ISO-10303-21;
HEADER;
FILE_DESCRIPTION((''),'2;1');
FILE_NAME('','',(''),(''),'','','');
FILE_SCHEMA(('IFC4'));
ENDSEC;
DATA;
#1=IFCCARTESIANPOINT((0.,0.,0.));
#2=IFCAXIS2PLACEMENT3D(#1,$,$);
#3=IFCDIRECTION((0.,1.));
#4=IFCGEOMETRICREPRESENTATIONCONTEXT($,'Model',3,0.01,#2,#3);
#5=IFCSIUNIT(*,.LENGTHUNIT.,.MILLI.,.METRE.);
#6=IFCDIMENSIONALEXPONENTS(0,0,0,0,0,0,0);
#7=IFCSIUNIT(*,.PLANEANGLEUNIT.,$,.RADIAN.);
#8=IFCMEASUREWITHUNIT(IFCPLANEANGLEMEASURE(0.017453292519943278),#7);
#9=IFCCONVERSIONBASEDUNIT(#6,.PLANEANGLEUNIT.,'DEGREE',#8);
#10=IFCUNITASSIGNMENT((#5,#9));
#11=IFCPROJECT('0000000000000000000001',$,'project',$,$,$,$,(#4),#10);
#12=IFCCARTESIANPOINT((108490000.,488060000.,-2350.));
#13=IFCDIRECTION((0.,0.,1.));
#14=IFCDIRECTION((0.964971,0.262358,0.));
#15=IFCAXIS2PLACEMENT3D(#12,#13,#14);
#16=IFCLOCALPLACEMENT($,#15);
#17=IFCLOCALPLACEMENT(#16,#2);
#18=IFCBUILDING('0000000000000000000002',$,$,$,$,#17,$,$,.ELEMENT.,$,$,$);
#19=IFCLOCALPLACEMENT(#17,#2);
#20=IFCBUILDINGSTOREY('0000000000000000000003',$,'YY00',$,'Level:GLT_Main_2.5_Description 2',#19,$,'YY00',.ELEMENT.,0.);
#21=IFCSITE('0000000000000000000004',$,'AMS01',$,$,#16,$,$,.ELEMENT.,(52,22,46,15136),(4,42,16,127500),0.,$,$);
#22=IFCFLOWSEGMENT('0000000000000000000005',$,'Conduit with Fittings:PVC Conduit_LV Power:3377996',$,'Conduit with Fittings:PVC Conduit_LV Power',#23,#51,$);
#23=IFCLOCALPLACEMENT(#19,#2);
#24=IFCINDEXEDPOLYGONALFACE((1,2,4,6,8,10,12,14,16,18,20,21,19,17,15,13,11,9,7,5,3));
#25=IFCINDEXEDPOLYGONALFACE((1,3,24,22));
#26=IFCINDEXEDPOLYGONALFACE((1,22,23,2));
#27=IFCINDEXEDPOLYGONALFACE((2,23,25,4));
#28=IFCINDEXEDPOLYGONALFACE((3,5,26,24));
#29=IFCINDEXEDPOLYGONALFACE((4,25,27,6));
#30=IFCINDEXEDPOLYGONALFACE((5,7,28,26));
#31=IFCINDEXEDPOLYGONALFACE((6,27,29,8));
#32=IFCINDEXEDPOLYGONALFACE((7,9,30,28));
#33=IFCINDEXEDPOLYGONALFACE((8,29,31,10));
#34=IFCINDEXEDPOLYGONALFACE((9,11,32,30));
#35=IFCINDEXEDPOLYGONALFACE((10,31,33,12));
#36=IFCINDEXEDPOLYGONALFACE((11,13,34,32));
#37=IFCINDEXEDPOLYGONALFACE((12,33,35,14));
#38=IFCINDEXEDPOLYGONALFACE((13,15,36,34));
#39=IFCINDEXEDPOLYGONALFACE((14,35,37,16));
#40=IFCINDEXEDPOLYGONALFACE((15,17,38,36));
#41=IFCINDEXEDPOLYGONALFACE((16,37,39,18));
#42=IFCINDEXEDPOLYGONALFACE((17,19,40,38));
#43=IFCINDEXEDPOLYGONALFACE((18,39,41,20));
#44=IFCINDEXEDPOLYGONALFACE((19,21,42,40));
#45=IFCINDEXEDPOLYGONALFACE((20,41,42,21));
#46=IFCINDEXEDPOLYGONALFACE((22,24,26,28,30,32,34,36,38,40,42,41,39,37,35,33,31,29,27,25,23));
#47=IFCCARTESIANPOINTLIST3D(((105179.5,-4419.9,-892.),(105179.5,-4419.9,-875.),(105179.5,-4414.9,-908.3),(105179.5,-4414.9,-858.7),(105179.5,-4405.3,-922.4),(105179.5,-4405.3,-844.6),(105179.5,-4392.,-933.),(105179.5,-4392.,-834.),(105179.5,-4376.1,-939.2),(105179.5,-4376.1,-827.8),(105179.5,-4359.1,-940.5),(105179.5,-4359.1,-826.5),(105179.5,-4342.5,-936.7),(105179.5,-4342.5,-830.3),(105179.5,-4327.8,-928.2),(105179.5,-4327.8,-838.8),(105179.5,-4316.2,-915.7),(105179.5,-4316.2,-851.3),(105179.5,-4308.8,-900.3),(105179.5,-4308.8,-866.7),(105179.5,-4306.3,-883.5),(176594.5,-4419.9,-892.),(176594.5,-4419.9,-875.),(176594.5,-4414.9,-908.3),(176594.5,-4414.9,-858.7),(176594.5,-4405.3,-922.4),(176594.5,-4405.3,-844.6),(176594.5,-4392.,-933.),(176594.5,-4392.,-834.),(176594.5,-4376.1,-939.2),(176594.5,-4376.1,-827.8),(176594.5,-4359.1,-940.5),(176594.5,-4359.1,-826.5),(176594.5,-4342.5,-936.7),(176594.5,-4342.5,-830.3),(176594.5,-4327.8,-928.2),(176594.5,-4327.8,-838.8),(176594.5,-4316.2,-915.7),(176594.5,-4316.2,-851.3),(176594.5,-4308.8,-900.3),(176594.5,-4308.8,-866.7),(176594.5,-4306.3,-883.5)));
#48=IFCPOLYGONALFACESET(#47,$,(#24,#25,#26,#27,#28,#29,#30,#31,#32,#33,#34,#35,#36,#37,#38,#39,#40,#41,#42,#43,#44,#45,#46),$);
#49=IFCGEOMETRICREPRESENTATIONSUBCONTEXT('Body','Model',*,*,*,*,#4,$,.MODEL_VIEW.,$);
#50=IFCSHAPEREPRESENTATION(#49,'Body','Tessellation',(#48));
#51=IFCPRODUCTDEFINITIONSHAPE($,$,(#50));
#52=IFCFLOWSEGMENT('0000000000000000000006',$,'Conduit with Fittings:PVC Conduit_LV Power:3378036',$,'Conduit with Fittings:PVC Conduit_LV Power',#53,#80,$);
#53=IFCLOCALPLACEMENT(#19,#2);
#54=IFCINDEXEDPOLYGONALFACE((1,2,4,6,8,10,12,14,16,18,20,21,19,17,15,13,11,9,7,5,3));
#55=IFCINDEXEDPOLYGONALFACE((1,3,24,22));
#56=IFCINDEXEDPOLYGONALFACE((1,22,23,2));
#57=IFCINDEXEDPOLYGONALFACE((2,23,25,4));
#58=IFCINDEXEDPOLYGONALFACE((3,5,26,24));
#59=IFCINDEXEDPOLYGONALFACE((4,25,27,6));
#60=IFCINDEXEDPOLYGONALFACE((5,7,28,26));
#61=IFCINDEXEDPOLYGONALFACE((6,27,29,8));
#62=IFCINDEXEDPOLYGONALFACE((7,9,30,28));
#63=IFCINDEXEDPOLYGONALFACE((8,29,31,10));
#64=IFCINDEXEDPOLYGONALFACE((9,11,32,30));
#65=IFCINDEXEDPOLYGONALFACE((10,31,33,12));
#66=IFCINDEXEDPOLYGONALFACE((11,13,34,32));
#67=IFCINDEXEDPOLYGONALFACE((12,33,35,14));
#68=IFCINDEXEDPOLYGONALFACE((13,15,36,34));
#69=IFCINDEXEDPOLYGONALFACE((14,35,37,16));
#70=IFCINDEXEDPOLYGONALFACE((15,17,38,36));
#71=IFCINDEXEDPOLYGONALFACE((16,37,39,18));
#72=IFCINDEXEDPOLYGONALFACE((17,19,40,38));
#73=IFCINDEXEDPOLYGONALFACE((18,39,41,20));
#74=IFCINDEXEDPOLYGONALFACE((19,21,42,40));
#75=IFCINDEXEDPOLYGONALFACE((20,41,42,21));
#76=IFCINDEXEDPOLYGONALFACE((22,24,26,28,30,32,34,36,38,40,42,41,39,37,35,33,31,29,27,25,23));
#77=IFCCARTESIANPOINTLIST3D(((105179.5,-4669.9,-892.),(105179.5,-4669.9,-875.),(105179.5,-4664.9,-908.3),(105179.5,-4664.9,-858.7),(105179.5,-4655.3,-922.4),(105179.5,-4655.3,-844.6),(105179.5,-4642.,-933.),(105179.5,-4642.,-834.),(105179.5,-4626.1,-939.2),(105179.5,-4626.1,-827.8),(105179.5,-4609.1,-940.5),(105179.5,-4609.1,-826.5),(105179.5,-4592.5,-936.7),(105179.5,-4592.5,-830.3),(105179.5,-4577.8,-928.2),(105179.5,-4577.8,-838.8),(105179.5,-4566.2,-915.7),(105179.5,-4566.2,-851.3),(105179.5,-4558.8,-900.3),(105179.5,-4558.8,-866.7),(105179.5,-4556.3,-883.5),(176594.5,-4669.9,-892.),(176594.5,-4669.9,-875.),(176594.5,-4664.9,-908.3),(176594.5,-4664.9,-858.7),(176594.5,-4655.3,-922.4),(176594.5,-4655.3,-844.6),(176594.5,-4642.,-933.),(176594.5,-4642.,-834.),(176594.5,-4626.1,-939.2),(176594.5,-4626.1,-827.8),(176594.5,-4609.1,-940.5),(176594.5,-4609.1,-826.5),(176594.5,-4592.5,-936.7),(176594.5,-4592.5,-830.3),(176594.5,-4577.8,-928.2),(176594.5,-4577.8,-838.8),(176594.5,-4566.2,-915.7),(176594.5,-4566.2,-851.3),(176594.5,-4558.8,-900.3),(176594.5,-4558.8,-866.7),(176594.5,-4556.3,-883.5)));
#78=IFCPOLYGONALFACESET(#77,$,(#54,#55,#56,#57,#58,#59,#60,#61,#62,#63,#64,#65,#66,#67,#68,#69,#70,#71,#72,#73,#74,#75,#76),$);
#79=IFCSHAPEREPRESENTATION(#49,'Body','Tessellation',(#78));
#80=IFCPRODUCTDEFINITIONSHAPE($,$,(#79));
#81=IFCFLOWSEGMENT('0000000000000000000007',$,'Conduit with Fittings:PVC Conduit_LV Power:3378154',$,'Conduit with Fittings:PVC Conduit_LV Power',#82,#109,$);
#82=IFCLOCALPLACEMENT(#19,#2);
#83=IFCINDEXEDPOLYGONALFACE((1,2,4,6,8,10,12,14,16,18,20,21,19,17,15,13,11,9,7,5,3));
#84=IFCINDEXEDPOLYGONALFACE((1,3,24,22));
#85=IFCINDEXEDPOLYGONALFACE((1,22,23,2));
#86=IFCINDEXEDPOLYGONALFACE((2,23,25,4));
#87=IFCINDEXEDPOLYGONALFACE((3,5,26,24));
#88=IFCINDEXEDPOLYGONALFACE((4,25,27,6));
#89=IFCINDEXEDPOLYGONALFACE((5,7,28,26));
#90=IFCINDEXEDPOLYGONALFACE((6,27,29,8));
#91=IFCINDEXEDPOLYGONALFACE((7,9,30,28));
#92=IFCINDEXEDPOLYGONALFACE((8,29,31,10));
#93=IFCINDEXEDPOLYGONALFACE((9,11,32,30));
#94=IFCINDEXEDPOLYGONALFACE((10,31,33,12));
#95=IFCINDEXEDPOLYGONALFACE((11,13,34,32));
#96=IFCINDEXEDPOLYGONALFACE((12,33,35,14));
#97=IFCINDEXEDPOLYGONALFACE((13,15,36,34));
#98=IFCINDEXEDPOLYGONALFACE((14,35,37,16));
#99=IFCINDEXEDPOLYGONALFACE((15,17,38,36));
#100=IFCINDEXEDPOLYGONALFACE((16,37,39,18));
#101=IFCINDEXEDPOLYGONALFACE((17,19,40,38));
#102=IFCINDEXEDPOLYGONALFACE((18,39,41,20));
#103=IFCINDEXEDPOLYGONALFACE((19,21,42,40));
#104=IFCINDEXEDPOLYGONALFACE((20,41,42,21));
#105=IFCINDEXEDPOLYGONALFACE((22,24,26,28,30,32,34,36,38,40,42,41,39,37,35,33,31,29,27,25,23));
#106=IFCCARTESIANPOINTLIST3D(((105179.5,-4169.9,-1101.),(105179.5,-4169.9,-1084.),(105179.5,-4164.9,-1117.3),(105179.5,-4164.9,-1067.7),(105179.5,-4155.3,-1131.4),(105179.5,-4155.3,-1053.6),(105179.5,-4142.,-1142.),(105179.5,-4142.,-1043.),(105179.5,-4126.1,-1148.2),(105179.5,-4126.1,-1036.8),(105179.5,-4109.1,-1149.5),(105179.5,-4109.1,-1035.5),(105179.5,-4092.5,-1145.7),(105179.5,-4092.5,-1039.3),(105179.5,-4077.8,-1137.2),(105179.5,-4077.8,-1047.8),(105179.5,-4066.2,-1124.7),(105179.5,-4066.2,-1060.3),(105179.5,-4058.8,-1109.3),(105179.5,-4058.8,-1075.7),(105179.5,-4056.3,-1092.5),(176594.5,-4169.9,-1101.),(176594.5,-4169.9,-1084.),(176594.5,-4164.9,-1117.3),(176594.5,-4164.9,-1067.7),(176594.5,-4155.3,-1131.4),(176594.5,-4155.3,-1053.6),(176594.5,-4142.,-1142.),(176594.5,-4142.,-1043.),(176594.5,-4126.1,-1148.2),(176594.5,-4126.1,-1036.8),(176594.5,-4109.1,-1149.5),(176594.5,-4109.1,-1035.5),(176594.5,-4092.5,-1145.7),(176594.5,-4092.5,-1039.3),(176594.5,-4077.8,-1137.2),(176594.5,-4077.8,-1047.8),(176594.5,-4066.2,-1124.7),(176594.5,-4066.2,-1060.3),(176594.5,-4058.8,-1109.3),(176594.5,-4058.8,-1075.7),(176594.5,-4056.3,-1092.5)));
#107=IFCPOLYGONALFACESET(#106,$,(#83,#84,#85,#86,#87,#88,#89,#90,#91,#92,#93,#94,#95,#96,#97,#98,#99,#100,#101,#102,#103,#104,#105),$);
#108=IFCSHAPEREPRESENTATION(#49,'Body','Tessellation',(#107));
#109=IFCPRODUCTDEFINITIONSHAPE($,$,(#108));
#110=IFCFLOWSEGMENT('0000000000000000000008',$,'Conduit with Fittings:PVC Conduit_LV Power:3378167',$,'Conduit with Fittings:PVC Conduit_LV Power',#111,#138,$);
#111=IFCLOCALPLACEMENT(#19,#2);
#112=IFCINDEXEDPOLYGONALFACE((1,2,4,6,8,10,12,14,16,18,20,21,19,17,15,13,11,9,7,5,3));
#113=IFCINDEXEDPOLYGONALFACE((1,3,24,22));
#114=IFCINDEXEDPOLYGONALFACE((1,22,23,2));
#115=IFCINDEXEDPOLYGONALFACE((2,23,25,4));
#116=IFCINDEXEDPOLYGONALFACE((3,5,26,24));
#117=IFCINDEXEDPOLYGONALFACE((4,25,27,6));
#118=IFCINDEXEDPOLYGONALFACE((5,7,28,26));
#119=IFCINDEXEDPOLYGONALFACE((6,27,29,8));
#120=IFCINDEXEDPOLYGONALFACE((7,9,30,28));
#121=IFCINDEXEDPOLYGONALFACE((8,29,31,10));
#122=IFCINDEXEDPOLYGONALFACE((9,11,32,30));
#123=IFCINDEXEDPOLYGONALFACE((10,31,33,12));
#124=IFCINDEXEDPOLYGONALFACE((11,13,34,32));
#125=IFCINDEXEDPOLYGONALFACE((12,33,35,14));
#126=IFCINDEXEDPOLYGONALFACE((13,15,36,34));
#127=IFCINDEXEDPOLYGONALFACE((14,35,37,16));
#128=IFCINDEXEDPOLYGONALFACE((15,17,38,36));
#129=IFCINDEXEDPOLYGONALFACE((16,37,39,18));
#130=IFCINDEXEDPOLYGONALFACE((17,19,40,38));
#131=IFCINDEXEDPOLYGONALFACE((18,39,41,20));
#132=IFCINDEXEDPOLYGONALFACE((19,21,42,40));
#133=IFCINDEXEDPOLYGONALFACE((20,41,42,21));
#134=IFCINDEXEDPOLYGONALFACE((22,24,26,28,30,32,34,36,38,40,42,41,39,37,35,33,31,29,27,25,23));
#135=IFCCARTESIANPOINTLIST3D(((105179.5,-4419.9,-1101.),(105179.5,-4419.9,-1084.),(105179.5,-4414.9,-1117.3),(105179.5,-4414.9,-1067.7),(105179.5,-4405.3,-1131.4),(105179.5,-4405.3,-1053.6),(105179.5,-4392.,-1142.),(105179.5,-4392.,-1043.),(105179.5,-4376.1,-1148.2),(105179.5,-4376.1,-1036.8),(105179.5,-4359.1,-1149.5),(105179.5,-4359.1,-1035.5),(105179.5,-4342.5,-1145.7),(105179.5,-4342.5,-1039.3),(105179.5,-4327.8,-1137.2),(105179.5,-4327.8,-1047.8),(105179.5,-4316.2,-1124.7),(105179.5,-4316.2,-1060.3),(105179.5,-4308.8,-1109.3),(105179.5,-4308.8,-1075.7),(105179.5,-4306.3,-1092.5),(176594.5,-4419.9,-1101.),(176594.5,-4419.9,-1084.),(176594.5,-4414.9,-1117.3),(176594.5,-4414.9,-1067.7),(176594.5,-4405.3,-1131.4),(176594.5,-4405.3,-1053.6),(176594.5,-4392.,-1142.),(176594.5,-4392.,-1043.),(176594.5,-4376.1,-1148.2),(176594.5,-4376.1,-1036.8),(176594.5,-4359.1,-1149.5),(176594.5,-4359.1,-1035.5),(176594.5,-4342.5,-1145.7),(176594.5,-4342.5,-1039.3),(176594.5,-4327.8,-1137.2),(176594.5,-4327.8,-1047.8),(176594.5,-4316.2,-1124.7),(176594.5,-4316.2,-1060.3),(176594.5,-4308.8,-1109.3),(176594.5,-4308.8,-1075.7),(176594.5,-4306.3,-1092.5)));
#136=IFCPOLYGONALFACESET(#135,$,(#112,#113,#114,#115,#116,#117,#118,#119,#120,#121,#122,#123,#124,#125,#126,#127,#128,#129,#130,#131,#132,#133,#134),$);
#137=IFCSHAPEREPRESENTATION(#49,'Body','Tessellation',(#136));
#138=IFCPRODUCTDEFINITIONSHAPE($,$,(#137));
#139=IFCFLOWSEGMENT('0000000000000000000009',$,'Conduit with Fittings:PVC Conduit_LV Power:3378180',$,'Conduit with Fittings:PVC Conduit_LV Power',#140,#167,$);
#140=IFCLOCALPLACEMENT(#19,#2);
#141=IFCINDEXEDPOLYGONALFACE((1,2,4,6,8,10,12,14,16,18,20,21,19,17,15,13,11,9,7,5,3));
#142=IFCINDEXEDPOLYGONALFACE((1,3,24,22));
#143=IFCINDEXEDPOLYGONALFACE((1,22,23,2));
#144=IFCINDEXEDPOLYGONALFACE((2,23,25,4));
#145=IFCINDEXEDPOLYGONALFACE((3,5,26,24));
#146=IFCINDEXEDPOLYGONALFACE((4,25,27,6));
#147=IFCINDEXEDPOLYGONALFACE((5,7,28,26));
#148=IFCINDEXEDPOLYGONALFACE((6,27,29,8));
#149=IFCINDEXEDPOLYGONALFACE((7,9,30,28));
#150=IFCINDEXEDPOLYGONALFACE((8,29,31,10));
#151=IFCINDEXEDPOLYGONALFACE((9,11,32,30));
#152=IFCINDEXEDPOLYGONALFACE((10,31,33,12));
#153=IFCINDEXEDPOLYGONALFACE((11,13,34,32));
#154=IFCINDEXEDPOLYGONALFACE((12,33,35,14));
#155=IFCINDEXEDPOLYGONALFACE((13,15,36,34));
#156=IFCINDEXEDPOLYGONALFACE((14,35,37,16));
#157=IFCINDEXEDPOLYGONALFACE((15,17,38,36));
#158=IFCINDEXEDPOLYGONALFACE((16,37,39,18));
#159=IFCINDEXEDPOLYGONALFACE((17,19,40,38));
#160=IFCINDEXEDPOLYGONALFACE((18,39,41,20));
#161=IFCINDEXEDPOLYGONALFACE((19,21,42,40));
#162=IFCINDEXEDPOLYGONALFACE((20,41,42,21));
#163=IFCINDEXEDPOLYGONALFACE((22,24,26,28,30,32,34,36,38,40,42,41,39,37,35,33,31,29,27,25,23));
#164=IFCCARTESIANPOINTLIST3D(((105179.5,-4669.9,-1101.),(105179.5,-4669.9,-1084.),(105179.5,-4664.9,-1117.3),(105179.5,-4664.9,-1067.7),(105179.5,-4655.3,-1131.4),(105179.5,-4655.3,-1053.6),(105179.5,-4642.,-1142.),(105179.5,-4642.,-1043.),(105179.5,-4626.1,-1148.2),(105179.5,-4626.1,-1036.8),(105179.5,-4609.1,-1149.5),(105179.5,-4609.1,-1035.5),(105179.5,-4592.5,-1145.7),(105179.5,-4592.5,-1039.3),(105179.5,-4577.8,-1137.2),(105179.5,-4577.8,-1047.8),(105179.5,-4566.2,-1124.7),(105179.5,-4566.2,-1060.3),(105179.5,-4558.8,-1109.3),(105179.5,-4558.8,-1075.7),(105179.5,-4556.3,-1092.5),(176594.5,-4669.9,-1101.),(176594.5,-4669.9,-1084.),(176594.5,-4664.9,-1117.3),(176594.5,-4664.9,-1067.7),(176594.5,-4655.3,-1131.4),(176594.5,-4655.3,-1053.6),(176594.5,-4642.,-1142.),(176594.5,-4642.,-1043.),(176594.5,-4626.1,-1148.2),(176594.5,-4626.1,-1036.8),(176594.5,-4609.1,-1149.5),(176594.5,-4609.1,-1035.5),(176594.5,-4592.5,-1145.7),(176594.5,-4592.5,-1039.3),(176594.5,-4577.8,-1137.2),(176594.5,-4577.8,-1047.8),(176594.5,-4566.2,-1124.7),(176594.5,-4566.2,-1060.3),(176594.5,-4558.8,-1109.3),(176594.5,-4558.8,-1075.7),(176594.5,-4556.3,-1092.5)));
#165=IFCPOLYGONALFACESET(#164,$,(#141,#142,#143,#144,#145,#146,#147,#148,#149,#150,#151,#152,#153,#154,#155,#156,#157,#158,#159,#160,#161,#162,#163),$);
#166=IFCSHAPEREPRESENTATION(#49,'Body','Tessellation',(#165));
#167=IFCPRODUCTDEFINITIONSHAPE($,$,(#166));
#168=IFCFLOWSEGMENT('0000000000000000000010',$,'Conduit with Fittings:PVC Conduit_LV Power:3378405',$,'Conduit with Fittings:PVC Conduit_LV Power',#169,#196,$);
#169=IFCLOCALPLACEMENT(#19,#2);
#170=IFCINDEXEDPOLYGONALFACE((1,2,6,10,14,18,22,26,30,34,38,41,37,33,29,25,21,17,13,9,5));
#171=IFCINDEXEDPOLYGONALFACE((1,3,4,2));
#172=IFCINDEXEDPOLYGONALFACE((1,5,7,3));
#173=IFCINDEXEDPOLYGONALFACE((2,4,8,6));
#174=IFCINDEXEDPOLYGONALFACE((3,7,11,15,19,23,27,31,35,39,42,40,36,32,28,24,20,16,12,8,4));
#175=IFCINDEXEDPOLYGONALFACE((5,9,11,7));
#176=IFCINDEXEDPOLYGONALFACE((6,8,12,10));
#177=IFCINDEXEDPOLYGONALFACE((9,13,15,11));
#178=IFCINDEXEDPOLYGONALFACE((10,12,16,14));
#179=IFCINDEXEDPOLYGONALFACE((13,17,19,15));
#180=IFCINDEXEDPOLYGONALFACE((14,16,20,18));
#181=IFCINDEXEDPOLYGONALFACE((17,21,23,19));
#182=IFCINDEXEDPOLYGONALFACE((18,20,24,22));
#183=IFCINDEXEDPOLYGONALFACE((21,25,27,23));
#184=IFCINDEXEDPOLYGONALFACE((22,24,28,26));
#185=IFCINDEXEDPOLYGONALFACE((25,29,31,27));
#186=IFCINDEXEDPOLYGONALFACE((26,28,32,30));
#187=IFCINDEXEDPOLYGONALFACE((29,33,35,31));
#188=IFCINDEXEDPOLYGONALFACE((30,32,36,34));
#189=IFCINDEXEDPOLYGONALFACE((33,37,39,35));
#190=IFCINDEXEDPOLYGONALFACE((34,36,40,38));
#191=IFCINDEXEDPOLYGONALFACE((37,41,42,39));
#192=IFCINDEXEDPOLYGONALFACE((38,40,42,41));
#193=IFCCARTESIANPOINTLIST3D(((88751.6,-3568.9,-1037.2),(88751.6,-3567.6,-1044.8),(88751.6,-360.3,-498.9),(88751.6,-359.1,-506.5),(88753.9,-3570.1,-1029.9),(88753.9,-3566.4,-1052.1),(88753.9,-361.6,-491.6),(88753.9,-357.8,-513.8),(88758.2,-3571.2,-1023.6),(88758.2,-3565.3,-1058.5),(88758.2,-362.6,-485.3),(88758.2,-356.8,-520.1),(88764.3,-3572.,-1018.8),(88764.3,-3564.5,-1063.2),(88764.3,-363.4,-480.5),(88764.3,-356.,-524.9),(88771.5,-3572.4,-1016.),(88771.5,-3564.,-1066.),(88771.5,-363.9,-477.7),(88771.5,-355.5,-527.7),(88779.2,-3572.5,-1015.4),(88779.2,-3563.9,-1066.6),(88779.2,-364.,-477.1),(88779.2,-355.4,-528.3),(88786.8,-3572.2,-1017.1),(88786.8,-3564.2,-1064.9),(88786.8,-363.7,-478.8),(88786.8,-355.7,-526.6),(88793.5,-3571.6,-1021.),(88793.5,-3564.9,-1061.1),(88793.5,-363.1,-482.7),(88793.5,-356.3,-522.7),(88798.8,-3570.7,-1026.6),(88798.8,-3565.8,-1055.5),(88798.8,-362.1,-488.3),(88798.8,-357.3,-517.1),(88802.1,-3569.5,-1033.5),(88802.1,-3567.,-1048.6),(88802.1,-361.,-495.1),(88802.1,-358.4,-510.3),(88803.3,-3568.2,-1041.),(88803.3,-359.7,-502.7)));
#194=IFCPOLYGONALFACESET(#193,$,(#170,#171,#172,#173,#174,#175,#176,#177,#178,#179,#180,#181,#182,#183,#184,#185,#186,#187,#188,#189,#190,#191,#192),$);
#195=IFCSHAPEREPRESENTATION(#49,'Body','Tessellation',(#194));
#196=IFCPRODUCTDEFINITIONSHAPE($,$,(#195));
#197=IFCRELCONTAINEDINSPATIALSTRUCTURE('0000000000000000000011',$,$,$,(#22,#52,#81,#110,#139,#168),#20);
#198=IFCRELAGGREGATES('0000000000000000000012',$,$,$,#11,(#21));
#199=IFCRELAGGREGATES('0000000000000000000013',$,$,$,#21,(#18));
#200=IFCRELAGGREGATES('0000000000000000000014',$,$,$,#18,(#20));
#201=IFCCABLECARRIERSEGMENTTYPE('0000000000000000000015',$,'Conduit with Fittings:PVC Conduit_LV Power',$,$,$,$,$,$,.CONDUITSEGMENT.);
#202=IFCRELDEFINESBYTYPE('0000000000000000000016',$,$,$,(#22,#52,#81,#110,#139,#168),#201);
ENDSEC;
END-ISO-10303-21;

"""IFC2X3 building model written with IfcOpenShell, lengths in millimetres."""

from ifc_helpers import new_model, entity, si_unit, converted_unit, direction, frame, frame_2d, origin, place, context, subcontext, project, spatial, circle, extrude, type_object, element, save


model = new_model("IFC2X3")

# Units and contexts
model_context = context("Model", 3, precision=0.01, world=origin(), true_north=direction((0.0, 1.0)))
body_context = subcontext(model_context, "Body", "Model", "MODEL_VIEW")
ifc_project = project(units=[si_unit("LENGTHUNIT", "METRE", prefix="MILLI"), converted_unit("PLANEANGLEUNIT", "DEGREE", entity("IfcPlaneAngleMeasure", 0.017453292519943278), si_unit("PLANEANGLEUNIT", "RADIAN"), dimensions=[0, 0, 0, 0, 0, 0, 0])], contexts=[model_context])

# Site, building, storey
site_placement = place(None, frame((108490000.0, 488060000.0, -2350.0), z_axis=(0.0, 0.0, 1.0), x_axis=(0.964971, 0.262358, 0.0)))
site = spatial("IfcSite", under=ifc_project, at=site_placement, Name="AMS01", CompositionType="ELEMENT", RefLatitude=(52, 22, 46, 15136), RefLongitude=(4, 42, 16, 127500), RefElevation=0.0)
building_placement = place(site_placement, origin())
building = spatial("IfcBuilding", under=site, at=building_placement, CompositionType="ELEMENT")
storey_placement = place(building_placement, origin())
storey = spatial("IfcBuildingStorey", under=building, at=storey_placement, Name="YY00", ObjectType="Level:GLT_Main_2.5_Description 2", LongName="YY00", CompositionType="ELEMENT", Elevation=0.0)

# Flow segments
cable_carrier_segment_type = type_object("IfcCableCarrierSegmentType", Name="Conduit with Fittings:PVC Conduit_LV Power", PredefinedType="CONDUITSEGMENT")
flow_segment_1_placement = place(storey_placement, origin())
element("IfcFlowSegment", 1, at=flow_segment_1_placement, inside=storey, type_object=cable_carrier_segment_type, Name="Conduit with Fittings:PVC Conduit_LV Power:3377996", ObjectType="Conduit with Fittings:PVC Conduit_LV Power", context=body_context, shape_type="SweptSolid", body=[
    extrude(circle(Radius=57.2, at=frame_2d((0.0, 0.0), x_axis=(1.0, 0.0))), frame((105179.5, -4363.4, -883.5), z_axis=(1.0, 0.0, 0.0), x_axis=(0.0, 1.0, 0.0)), (0.0, 0.0, 1.0), 71415.0),
])
flow_segment_2_placement = place(storey_placement, origin())
element("IfcFlowSegment", 2, at=flow_segment_2_placement, inside=storey, type_object=cable_carrier_segment_type, Name="Conduit with Fittings:PVC Conduit_LV Power:3378036", ObjectType="Conduit with Fittings:PVC Conduit_LV Power", context=body_context, shape_type="SweptSolid", body=[
    extrude(circle(Radius=57.2, at=frame_2d((0.0, 0.0), x_axis=(1.0, 0.0))), frame((105179.5, -4613.4, -883.5), z_axis=(1.0, 0.0, 0.0), x_axis=(0.0, 1.0, 0.0)), (0.0, 0.0, 1.0), 71415.0),
])
flow_segment_3_placement = place(storey_placement, origin())
element("IfcFlowSegment", 3, at=flow_segment_3_placement, inside=storey, type_object=cable_carrier_segment_type, Name="Conduit with Fittings:PVC Conduit_LV Power:3378154", ObjectType="Conduit with Fittings:PVC Conduit_LV Power", context=body_context, shape_type="SweptSolid", body=[
    extrude(circle(Radius=57.2, at=frame_2d((0.0, 0.0), x_axis=(1.0, 0.0))), frame((105179.5, -4113.4, -1092.5), z_axis=(1.0, 0.0, 0.0), x_axis=(0.0, 1.0, 0.0)), (0.0, 0.0, 1.0), 71415.0),
])
flow_segment_4_placement = place(storey_placement, origin())
element("IfcFlowSegment", 4, at=flow_segment_4_placement, inside=storey, type_object=cable_carrier_segment_type, Name="Conduit with Fittings:PVC Conduit_LV Power:3378167", ObjectType="Conduit with Fittings:PVC Conduit_LV Power", context=body_context, shape_type="SweptSolid", body=[
    extrude(circle(Radius=57.2, at=frame_2d((0.0, 0.0), x_axis=(1.0, 0.0))), frame((105179.5, -4363.4, -1092.5), z_axis=(1.0, 0.0, 0.0), x_axis=(0.0, 1.0, 0.0)), (0.0, 0.0, 1.0), 71415.0),
])
flow_segment_5_placement = place(storey_placement, origin())
element("IfcFlowSegment", 5, at=flow_segment_5_placement, inside=storey, type_object=cable_carrier_segment_type, Name="Conduit with Fittings:PVC Conduit_LV Power:3378180", ObjectType="Conduit with Fittings:PVC Conduit_LV Power", context=body_context, shape_type="SweptSolid", body=[
    extrude(circle(Radius=57.2, at=frame_2d((0.0, 0.0), x_axis=(1.0, 0.0))), frame((105179.5, -4613.4, -1092.5), z_axis=(1.0, 0.0, 0.0), x_axis=(0.0, 1.0, 0.0)), (0.0, 0.0, 1.0), 71415.0),
])
flow_segment_6_placement = place(storey_placement, origin())
element("IfcFlowSegment", 6, at=flow_segment_6_placement, inside=storey, type_object=cable_carrier_segment_type, Name="Conduit with Fittings:PVC Conduit_LV Power:3378405", ObjectType="Conduit with Fittings:PVC Conduit_LV Power", context=body_context, shape_type="SweptSolid", body=[
    extrude(circle(Radius=26.0, at=frame_2d((0.0, 0.0), x_axis=(1.0, 0.0))), frame((88777.3, -3568.2, -1041.0), z_axis=(0.0, 0.986216, 0.165463), x_axis=(1.0, 0.0, 0.0)), (0.0, 0.0, 1.0), 3253.4),
])

save(model, "model.ifc")
